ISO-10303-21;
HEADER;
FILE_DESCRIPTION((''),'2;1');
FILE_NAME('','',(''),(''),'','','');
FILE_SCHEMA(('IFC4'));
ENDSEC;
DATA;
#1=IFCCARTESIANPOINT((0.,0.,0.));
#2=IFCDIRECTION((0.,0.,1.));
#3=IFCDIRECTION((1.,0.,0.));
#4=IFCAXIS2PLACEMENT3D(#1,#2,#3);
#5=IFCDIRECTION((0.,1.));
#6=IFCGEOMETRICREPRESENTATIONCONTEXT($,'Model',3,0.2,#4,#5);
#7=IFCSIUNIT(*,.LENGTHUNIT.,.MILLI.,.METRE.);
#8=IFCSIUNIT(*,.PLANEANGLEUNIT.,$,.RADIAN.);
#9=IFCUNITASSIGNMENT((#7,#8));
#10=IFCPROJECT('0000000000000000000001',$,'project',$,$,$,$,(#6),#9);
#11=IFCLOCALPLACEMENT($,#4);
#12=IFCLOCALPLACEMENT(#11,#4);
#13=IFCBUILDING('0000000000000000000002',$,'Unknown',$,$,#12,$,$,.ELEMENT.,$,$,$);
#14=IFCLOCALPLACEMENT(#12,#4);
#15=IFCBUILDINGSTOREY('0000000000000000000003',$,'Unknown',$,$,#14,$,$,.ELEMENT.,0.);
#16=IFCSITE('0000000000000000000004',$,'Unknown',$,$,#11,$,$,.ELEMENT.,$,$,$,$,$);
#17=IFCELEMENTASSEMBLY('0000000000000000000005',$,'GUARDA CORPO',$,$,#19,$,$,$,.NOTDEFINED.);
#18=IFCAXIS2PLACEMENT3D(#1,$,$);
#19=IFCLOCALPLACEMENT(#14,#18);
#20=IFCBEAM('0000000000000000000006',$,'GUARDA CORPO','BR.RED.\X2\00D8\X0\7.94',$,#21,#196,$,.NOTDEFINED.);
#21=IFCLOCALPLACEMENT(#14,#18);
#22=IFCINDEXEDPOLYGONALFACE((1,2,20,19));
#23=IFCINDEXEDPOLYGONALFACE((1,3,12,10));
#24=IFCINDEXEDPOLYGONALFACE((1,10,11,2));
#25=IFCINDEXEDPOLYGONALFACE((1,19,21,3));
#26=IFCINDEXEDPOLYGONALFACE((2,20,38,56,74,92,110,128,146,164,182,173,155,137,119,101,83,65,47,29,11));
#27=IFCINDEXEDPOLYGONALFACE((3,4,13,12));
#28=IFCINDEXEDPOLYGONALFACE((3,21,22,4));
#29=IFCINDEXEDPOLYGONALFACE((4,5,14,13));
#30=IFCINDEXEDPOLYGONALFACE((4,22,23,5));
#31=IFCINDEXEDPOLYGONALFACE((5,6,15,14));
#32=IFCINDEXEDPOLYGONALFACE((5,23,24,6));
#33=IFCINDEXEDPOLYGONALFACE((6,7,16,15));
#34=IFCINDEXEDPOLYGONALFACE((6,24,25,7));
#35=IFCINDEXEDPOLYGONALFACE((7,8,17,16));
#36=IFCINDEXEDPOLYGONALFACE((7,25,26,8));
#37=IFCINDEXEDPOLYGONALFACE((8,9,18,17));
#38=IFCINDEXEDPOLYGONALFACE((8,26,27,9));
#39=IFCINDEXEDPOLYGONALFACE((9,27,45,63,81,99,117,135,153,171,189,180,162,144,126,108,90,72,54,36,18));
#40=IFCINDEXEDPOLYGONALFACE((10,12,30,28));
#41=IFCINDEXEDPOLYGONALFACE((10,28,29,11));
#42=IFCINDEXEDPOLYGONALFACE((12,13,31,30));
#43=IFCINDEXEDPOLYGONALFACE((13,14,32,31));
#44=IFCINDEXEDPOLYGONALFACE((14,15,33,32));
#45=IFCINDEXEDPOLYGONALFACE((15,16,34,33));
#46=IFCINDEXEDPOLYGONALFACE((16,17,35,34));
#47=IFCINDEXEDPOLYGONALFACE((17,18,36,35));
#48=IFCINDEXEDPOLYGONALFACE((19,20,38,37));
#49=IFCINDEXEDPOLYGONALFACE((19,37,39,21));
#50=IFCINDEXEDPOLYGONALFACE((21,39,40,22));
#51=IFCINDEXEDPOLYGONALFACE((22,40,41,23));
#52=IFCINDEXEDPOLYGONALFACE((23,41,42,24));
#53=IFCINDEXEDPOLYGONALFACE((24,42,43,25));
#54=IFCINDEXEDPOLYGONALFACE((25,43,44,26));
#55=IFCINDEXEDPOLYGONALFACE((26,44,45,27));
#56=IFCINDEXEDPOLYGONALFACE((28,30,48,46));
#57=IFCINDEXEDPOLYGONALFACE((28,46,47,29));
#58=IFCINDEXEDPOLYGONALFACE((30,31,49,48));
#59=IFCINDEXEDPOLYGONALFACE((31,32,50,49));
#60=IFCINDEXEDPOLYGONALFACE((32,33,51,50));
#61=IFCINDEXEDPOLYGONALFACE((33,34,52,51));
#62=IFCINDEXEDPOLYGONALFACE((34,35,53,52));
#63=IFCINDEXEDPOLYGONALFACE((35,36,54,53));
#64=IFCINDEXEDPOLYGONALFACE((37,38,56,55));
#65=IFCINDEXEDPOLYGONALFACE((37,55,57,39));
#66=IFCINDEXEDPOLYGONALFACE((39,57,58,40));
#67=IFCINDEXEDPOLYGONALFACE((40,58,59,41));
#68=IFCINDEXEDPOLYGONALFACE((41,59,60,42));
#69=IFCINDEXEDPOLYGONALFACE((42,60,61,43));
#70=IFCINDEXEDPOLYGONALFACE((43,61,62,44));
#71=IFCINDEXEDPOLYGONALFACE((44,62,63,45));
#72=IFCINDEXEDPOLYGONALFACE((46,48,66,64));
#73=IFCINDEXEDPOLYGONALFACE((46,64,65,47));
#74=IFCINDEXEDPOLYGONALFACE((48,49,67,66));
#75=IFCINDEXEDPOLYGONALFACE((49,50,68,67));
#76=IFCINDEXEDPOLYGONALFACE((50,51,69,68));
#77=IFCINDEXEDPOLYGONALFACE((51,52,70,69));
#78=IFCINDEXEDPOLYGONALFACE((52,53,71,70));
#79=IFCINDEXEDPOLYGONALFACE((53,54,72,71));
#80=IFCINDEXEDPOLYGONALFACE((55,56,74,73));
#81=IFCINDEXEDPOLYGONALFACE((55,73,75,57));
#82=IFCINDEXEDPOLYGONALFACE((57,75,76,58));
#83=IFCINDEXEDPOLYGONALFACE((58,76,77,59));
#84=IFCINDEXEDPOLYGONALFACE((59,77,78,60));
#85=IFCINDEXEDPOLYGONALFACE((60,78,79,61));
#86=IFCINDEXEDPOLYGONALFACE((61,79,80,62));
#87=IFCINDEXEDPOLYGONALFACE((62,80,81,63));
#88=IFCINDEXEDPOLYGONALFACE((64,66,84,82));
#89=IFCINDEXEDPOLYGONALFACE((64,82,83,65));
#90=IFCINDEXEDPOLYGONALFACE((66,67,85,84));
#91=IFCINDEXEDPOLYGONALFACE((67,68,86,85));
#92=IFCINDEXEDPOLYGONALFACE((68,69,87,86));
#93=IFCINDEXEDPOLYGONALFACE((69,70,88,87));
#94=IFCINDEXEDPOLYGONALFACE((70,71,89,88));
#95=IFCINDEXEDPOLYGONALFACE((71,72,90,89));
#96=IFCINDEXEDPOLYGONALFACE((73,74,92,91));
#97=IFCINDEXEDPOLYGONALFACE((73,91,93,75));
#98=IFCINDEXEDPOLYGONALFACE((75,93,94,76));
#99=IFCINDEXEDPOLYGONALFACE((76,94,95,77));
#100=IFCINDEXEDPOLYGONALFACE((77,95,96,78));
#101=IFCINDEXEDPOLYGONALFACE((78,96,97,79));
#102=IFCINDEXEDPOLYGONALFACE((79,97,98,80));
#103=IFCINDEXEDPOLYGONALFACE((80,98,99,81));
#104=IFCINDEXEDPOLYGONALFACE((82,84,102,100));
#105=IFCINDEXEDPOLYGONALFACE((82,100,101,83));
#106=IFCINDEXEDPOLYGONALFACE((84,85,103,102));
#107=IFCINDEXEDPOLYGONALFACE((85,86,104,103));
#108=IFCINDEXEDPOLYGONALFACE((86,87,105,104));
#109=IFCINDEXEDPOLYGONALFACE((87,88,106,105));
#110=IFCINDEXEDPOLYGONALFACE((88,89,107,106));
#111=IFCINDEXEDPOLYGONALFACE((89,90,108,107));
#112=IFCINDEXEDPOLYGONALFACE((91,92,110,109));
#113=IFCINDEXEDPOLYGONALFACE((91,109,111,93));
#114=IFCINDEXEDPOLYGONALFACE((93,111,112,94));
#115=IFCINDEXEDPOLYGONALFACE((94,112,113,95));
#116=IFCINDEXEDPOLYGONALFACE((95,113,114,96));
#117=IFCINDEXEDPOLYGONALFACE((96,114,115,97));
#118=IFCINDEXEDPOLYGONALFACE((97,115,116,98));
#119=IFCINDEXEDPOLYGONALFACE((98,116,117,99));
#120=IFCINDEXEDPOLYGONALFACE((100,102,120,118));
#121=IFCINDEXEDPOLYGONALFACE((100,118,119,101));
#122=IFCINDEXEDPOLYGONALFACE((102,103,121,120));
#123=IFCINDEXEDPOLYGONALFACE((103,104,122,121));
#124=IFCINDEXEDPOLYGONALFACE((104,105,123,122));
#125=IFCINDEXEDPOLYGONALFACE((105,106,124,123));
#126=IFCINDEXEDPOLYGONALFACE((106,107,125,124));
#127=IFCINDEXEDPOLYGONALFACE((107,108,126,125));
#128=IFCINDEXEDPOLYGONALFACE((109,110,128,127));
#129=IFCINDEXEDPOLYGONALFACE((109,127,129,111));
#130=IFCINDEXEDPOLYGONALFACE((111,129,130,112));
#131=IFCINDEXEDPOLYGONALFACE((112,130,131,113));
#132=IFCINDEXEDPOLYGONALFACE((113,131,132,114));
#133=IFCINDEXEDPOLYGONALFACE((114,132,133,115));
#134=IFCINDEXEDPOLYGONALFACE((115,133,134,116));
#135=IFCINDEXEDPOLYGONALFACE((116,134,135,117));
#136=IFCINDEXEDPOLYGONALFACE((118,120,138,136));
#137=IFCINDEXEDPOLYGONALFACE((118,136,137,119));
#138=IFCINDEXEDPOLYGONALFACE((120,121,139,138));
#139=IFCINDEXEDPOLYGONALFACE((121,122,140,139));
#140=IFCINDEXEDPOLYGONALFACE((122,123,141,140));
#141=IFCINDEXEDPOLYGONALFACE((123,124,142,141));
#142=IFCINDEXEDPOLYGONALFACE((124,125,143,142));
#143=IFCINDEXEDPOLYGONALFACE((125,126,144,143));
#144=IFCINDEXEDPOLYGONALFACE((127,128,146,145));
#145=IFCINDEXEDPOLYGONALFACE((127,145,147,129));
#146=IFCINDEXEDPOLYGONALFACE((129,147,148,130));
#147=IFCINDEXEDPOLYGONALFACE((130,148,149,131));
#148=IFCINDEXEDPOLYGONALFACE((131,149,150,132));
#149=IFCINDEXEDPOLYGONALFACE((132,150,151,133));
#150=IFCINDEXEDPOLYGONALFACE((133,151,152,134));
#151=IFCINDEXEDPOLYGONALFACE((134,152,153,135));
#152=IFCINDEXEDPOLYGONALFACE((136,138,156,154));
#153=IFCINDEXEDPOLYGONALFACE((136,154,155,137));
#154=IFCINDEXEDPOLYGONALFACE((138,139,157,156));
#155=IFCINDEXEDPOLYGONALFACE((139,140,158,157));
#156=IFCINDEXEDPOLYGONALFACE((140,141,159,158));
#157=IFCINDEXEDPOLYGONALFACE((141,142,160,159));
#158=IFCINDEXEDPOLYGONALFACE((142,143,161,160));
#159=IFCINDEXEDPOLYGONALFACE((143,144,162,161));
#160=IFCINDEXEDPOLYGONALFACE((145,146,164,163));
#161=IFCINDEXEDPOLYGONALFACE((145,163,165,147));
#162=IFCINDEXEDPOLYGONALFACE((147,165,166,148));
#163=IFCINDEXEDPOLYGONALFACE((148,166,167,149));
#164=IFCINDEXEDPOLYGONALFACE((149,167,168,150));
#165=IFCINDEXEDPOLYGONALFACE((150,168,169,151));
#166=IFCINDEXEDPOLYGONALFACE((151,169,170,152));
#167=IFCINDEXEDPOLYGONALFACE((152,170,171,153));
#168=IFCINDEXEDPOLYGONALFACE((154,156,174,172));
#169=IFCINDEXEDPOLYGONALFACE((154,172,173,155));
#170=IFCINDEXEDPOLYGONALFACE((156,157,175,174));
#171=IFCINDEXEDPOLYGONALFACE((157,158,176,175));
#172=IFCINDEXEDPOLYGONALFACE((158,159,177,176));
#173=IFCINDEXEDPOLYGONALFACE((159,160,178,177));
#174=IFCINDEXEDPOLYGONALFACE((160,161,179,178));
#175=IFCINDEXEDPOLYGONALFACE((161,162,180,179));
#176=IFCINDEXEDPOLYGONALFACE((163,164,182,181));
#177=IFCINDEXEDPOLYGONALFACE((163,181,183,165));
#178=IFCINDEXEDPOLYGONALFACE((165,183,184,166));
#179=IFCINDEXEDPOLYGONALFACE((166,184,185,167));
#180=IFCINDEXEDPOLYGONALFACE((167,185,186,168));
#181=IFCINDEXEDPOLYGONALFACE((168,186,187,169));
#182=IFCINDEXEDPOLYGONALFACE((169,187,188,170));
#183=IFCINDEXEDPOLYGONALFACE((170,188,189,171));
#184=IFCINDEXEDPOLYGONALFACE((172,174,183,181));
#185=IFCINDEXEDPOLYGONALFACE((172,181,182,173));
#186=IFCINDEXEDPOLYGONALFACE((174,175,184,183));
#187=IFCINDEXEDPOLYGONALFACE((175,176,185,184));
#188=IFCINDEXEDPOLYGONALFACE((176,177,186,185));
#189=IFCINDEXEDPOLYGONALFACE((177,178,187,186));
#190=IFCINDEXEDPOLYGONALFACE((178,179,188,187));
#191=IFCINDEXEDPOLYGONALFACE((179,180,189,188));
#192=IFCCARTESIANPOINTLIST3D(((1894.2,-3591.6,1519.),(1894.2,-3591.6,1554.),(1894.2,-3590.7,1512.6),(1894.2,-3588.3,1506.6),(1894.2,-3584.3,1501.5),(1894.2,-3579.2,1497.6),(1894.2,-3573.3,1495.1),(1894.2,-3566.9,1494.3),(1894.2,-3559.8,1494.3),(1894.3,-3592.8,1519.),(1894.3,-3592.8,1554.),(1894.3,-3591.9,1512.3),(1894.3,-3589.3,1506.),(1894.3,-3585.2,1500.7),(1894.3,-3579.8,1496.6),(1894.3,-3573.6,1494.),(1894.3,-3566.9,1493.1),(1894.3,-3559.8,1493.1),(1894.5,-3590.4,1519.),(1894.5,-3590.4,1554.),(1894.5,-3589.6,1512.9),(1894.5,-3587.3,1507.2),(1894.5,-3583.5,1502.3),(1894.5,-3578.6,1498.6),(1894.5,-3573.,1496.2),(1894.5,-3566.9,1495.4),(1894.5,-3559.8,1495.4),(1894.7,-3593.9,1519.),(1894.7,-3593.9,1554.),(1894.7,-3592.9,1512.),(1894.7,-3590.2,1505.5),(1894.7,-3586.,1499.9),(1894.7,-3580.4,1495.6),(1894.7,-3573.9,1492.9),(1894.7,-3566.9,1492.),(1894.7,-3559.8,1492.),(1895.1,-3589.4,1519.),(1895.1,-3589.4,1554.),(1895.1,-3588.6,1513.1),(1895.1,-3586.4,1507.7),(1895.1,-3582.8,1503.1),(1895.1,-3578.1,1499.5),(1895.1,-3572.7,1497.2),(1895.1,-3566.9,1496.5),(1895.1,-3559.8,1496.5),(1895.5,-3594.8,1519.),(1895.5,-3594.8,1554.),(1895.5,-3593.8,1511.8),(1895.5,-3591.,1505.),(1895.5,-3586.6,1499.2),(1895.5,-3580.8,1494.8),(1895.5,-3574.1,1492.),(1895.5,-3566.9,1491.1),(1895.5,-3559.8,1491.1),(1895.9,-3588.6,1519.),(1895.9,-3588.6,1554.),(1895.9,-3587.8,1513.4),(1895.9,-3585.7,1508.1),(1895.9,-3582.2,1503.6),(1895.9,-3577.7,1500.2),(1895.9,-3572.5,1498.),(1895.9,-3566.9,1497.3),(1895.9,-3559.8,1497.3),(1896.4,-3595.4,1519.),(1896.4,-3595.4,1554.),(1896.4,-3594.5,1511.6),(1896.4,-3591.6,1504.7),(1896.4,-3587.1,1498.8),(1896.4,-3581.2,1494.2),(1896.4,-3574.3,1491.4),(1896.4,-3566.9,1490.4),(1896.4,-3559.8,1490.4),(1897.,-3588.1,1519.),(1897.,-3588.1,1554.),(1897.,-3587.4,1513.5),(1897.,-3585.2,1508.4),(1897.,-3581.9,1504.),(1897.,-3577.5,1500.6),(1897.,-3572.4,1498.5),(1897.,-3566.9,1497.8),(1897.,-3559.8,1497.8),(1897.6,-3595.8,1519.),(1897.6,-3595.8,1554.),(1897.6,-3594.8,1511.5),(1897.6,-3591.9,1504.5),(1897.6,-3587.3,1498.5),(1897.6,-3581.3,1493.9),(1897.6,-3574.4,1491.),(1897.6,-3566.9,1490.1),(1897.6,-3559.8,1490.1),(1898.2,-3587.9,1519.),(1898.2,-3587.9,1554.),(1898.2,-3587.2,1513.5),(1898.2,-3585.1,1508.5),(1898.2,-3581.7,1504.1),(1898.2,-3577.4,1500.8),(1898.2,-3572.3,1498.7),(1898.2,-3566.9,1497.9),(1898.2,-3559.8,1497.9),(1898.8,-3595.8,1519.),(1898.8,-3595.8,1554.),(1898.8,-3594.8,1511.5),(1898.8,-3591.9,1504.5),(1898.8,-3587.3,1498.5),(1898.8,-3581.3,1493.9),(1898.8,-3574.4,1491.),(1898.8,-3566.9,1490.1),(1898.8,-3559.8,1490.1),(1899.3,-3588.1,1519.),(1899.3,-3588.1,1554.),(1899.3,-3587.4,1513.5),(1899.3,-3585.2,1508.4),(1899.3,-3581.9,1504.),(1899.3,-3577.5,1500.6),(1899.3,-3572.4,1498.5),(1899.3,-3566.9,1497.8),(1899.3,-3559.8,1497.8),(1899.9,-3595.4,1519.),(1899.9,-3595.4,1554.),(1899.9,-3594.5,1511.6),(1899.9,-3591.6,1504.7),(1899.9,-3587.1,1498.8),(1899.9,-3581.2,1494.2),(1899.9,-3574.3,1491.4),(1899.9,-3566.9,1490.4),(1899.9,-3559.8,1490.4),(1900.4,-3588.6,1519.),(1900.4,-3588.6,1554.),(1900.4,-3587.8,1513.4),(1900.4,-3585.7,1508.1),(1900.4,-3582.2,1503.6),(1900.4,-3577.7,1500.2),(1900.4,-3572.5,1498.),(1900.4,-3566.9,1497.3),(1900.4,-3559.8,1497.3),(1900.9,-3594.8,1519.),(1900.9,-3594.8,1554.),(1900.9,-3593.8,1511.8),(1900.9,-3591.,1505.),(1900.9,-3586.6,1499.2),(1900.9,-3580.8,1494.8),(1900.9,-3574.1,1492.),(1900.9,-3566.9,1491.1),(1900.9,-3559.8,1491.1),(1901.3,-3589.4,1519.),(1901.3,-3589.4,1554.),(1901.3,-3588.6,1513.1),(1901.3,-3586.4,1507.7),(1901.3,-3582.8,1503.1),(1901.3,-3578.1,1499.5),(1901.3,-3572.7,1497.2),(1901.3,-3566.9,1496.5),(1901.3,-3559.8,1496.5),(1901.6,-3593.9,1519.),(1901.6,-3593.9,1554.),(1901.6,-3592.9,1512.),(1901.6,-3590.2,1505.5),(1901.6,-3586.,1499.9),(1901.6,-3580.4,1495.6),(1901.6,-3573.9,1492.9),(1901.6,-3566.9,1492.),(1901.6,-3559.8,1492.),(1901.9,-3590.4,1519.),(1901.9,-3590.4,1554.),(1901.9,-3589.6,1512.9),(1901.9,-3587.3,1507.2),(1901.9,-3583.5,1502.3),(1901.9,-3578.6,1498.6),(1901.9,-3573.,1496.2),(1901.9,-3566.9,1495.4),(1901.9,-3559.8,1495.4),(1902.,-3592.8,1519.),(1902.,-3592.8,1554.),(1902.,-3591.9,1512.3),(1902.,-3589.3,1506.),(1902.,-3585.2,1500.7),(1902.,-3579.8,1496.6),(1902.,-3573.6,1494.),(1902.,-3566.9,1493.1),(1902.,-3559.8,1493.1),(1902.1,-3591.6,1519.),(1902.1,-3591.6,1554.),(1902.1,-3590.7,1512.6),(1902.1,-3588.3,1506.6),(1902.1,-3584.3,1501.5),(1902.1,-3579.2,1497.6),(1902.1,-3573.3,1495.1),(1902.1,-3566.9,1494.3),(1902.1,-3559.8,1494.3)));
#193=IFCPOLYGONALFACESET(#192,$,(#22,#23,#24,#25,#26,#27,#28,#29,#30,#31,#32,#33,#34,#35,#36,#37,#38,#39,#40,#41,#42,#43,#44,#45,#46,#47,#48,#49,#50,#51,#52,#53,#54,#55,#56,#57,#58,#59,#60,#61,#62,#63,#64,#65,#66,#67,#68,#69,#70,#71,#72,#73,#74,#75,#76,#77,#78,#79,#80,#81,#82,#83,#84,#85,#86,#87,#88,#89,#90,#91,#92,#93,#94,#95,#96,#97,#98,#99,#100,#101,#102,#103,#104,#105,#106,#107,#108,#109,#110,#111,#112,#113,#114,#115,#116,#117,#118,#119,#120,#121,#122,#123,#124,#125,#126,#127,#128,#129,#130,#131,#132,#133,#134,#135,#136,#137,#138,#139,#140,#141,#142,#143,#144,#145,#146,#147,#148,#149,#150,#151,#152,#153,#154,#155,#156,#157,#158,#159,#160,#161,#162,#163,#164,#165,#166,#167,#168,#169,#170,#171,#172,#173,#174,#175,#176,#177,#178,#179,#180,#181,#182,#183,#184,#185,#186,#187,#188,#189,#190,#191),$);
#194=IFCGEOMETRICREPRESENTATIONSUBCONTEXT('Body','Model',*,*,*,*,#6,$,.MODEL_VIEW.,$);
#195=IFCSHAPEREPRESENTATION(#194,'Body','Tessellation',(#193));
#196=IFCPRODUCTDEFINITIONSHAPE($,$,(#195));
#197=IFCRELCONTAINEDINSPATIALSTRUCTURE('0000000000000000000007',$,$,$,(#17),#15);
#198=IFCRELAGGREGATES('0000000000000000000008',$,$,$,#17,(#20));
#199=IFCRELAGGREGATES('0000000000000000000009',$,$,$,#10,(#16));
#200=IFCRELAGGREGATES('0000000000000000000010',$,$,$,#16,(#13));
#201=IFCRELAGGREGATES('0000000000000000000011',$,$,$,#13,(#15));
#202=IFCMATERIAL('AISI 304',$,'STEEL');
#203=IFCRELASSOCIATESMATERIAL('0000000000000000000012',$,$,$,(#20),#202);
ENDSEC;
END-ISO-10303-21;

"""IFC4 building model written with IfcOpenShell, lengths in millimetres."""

from ifc_helpers import new_model, entity, si_unit, direction, frame, origin_with_axes, place, context, subcontext, project, spatial, material, element, aggregate, save


model = new_model("IFC4")

# Units and contexts
model_context = context("Model", 3, precision=0.2, world=origin_with_axes(), true_north=direction((0.0, 1.0)))
body_context = subcontext(model_context, "Body", "Model", "MODEL_VIEW")
ifc_project = project(units=[si_unit("LENGTHUNIT", "METRE", prefix="MILLI"), si_unit("PLANEANGLEUNIT", "RADIAN")], contexts=[model_context])

# Site, building, storey
site_placement = place(None, origin_with_axes())
site = spatial("IfcSite", under=ifc_project, at=site_placement, Name="Unknown", CompositionType="ELEMENT")
building_placement = place(site_placement, origin_with_axes())
building = spatial("IfcBuilding", under=site, at=building_placement, Name="Unknown", CompositionType="ELEMENT")
storey_placement = place(building_placement, origin_with_axes())
storey = spatial("IfcBuildingStorey", under=building, at=storey_placement, Name="Unknown", CompositionType="ELEMENT", Elevation=0.0)

# Shared definitions
ifc_material_1 = material(Name="AISI 304", Category="STEEL")

# Element assembly, beam
assembly_1_placement = place(storey_placement, frame((833.2, -3540.7, 1615.0), z_axis=(-0.000512, -1.0, -0.000003), x_axis=(0.000003, -0.000003, 1.0)))
assembly_1 = element("IfcElementAssembly", 1, at=assembly_1_placement, inside=storey, Name="GUARDA CORPO", PredefinedType="NOTDEFINED")
beam_1_placement = place(assembly_1_placement, frame((-61.0, -1065.0, 50.6), z_axis=(-0.000003, 0.000513, -1.0), x_axis=(-1.0, 0.0, 0.000003)))
beam_1 = element("IfcBeam", 2, at=beam_1_placement, material=ifc_material_1, Name="GUARDA CORPO", Description="BR.RED.Ø7.94", PredefinedType="NOTDEFINED", context=body_context, shape_type="SolidModel", body=[
    entity("IfcSweptDiskSolid", entity("IfcIndexedPolyCurve", entity("IfcCartesianPointList3D", [[0.0, 0.0, 0.0], [35.0, 0.0, 0.0], [52.7, 0.0, 7.3], [60.0, 0.0, 25.0], [60.0, 0.0, 32.1]]), [entity("IfcLineIndex", [1, 2]), entity("IfcArcIndex", [2, 3, 4]), entity("IfcLineIndex", [4, 5])]), 4.0),
])

aggregate(assembly_1, [beam_1])

save(model, "model.ifc")
